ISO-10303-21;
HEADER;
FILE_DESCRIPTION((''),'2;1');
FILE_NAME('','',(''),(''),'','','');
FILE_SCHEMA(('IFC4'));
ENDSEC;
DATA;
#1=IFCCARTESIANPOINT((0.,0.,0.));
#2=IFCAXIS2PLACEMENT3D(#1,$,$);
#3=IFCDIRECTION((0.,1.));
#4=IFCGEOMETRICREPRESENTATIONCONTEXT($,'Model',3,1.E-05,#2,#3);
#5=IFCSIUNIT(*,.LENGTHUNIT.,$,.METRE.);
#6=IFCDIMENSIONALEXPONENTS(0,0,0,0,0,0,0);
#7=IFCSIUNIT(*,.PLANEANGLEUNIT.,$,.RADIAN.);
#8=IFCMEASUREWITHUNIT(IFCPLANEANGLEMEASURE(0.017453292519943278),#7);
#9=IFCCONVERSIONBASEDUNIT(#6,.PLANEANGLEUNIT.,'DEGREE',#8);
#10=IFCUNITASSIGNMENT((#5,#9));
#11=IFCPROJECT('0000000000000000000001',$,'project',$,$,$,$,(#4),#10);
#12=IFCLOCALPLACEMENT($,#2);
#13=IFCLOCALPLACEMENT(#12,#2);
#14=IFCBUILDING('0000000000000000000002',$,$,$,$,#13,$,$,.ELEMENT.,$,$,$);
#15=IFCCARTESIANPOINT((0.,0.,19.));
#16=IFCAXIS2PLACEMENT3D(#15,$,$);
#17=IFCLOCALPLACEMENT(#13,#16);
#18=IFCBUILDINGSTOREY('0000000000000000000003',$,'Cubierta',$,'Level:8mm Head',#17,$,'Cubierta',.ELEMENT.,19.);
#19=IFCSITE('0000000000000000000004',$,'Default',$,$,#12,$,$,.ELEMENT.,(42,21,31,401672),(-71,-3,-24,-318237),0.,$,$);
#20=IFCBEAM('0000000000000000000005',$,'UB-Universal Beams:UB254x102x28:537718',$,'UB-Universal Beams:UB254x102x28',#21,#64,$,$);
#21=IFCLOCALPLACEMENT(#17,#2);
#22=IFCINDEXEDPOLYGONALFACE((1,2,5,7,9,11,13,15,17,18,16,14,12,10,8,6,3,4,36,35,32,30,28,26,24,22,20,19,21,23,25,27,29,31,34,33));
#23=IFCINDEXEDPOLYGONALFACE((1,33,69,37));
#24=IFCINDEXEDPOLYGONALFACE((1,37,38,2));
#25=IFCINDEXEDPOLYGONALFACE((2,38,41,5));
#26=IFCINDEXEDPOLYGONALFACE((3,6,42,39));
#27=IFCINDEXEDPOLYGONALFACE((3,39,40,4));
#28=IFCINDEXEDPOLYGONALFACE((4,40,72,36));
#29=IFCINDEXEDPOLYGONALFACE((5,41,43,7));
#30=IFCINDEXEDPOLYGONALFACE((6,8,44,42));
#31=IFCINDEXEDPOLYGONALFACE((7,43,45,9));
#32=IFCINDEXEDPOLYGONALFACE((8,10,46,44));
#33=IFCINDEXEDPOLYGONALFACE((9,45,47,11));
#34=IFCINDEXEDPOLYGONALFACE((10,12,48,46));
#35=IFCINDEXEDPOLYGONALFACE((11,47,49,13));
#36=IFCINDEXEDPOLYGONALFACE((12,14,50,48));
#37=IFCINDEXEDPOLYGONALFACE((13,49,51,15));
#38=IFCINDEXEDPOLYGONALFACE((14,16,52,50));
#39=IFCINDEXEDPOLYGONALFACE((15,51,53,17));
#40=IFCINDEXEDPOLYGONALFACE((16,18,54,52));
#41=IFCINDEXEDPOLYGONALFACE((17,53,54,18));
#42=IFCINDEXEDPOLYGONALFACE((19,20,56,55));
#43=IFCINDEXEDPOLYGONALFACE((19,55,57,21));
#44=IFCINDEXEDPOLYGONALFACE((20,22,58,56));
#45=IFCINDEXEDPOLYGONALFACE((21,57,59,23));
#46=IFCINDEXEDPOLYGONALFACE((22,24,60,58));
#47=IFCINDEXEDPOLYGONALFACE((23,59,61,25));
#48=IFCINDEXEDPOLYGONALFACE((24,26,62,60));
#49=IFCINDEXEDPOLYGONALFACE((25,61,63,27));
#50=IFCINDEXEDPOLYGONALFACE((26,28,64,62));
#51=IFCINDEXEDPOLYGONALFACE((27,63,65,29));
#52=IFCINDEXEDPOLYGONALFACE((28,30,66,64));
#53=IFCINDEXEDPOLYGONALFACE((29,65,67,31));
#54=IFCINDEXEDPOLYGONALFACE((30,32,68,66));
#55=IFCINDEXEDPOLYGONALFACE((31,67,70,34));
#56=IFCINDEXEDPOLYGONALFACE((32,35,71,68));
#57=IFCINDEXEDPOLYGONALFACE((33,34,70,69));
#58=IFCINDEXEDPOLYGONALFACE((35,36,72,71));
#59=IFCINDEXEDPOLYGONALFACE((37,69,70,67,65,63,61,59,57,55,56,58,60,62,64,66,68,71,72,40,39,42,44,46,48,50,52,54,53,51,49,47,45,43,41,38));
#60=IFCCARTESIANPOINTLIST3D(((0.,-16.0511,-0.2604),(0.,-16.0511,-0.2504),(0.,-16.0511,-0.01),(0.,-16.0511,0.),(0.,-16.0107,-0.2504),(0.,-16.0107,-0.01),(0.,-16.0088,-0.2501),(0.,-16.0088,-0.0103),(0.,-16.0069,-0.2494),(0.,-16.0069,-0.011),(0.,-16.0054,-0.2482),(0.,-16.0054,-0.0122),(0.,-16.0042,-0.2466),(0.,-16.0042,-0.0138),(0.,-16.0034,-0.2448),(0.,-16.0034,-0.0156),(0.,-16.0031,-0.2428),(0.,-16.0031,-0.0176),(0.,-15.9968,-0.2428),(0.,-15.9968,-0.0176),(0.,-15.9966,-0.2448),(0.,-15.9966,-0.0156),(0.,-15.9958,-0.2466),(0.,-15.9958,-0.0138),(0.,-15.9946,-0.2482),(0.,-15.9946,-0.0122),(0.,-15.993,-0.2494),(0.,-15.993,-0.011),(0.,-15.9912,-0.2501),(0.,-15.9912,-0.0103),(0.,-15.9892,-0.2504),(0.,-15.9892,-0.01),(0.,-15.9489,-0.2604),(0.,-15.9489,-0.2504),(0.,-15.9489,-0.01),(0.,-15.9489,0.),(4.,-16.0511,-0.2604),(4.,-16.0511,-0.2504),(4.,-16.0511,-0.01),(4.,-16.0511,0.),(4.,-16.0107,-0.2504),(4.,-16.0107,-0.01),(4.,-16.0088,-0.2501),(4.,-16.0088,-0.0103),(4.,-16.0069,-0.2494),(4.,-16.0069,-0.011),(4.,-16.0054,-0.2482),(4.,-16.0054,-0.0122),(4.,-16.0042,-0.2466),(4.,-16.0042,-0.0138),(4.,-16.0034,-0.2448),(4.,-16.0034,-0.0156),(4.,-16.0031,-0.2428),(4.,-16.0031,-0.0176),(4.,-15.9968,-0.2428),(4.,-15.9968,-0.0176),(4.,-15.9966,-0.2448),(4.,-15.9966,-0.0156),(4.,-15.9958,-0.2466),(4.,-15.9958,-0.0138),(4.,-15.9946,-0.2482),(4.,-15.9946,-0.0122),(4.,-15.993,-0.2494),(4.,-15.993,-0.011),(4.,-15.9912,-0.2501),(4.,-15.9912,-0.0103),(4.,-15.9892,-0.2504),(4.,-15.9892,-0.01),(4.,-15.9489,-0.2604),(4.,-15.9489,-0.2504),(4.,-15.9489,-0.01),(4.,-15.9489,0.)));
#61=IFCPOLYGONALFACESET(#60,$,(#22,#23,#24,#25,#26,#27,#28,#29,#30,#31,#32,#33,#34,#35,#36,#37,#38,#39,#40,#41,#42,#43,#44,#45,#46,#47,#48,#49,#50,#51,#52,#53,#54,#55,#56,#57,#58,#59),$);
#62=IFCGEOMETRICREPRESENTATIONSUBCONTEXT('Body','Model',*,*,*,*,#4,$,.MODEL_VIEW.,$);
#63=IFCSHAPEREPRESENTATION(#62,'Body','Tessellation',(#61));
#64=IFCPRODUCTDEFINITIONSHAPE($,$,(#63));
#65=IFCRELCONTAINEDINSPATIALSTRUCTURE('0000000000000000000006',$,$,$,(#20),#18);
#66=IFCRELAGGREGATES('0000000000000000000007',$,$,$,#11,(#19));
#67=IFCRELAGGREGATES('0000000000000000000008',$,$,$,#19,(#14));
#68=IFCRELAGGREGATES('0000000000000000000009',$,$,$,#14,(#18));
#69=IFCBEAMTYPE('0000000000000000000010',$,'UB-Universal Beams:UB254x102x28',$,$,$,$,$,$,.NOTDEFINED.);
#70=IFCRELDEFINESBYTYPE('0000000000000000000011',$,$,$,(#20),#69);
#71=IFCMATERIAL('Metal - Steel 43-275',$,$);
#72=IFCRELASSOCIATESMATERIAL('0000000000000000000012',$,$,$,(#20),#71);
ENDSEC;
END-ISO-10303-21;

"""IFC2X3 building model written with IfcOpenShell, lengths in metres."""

from ifc_helpers import new_model, entity, si_unit, converted_unit, direction, frame, frame_2d, origin, place, context, subcontext, project, spatial, i_section, extrude, material, type_object, element, save


model = new_model("IFC2X3")

# Units and contexts
model_context = context("Model", 3, precision=1e-05, world=origin(), true_north=direction((0.0, 1.0)))
body_context = subcontext(model_context, "Body", "Model", "MODEL_VIEW")
ifc_project = project(units=[si_unit("LENGTHUNIT", "METRE"), converted_unit("PLANEANGLEUNIT", "DEGREE", entity("IfcPlaneAngleMeasure", 0.017453292519943278), si_unit("PLANEANGLEUNIT", "RADIAN"), dimensions=[0, 0, 0, 0, 0, 0, 0])], contexts=[model_context])

# Site, building, storey
site_placement = place(None, origin())
site = spatial("IfcSite", under=ifc_project, at=site_placement, Name="Default", CompositionType="ELEMENT", RefLatitude=(42, 21, 31, 401672), RefLongitude=(-71, -3, -24, -318237), RefElevation=0.0)
building_placement = place(site_placement, origin())
building = spatial("IfcBuilding", under=site, at=building_placement, CompositionType="ELEMENT")
storey_placement = place(building_placement, frame((0.0, 0.0, 19.0)))
storey = spatial("IfcBuildingStorey", under=building, at=storey_placement, Name="Cubierta", ObjectType="Level:8mm Head", LongName="Cubierta", CompositionType="ELEMENT", Elevation=19.0)

# Beam
ifc_material = material(Name="Metal - Steel 43-275")
beam_type = type_object("IfcBeamType", Name="UB-Universal Beams:UB254x102x28", PredefinedType="NOTDEFINED")
beam_1_placement = place(storey_placement, frame((0.0, -16.0, 0.0)))
element("IfcBeam", 1, at=beam_1_placement, inside=storey, type_object=beam_type, material=ifc_material, Name="UB-Universal Beams:UB254x102x28:537718", ObjectType="UB-Universal Beams:UB254x102x28", context=body_context, shape_type="SweptSolid", body=[
    extrude(i_section(OverallWidth=0.1022, OverallDepth=0.2604, WebThickness=0.0063, FlangeThickness=0.01, FilletRadius=0.0076, at=frame_2d((0.0, 0.0), x_axis=(0.0, 1.0))), frame((0.0, 0.0, -0.1302), z_axis=(1.0, 0.0, 0.0), x_axis=(0.0, 0.0, -1.0)), (0.0, 0.0, 1.0), 4.0),
])

save(model, "model.ifc")
